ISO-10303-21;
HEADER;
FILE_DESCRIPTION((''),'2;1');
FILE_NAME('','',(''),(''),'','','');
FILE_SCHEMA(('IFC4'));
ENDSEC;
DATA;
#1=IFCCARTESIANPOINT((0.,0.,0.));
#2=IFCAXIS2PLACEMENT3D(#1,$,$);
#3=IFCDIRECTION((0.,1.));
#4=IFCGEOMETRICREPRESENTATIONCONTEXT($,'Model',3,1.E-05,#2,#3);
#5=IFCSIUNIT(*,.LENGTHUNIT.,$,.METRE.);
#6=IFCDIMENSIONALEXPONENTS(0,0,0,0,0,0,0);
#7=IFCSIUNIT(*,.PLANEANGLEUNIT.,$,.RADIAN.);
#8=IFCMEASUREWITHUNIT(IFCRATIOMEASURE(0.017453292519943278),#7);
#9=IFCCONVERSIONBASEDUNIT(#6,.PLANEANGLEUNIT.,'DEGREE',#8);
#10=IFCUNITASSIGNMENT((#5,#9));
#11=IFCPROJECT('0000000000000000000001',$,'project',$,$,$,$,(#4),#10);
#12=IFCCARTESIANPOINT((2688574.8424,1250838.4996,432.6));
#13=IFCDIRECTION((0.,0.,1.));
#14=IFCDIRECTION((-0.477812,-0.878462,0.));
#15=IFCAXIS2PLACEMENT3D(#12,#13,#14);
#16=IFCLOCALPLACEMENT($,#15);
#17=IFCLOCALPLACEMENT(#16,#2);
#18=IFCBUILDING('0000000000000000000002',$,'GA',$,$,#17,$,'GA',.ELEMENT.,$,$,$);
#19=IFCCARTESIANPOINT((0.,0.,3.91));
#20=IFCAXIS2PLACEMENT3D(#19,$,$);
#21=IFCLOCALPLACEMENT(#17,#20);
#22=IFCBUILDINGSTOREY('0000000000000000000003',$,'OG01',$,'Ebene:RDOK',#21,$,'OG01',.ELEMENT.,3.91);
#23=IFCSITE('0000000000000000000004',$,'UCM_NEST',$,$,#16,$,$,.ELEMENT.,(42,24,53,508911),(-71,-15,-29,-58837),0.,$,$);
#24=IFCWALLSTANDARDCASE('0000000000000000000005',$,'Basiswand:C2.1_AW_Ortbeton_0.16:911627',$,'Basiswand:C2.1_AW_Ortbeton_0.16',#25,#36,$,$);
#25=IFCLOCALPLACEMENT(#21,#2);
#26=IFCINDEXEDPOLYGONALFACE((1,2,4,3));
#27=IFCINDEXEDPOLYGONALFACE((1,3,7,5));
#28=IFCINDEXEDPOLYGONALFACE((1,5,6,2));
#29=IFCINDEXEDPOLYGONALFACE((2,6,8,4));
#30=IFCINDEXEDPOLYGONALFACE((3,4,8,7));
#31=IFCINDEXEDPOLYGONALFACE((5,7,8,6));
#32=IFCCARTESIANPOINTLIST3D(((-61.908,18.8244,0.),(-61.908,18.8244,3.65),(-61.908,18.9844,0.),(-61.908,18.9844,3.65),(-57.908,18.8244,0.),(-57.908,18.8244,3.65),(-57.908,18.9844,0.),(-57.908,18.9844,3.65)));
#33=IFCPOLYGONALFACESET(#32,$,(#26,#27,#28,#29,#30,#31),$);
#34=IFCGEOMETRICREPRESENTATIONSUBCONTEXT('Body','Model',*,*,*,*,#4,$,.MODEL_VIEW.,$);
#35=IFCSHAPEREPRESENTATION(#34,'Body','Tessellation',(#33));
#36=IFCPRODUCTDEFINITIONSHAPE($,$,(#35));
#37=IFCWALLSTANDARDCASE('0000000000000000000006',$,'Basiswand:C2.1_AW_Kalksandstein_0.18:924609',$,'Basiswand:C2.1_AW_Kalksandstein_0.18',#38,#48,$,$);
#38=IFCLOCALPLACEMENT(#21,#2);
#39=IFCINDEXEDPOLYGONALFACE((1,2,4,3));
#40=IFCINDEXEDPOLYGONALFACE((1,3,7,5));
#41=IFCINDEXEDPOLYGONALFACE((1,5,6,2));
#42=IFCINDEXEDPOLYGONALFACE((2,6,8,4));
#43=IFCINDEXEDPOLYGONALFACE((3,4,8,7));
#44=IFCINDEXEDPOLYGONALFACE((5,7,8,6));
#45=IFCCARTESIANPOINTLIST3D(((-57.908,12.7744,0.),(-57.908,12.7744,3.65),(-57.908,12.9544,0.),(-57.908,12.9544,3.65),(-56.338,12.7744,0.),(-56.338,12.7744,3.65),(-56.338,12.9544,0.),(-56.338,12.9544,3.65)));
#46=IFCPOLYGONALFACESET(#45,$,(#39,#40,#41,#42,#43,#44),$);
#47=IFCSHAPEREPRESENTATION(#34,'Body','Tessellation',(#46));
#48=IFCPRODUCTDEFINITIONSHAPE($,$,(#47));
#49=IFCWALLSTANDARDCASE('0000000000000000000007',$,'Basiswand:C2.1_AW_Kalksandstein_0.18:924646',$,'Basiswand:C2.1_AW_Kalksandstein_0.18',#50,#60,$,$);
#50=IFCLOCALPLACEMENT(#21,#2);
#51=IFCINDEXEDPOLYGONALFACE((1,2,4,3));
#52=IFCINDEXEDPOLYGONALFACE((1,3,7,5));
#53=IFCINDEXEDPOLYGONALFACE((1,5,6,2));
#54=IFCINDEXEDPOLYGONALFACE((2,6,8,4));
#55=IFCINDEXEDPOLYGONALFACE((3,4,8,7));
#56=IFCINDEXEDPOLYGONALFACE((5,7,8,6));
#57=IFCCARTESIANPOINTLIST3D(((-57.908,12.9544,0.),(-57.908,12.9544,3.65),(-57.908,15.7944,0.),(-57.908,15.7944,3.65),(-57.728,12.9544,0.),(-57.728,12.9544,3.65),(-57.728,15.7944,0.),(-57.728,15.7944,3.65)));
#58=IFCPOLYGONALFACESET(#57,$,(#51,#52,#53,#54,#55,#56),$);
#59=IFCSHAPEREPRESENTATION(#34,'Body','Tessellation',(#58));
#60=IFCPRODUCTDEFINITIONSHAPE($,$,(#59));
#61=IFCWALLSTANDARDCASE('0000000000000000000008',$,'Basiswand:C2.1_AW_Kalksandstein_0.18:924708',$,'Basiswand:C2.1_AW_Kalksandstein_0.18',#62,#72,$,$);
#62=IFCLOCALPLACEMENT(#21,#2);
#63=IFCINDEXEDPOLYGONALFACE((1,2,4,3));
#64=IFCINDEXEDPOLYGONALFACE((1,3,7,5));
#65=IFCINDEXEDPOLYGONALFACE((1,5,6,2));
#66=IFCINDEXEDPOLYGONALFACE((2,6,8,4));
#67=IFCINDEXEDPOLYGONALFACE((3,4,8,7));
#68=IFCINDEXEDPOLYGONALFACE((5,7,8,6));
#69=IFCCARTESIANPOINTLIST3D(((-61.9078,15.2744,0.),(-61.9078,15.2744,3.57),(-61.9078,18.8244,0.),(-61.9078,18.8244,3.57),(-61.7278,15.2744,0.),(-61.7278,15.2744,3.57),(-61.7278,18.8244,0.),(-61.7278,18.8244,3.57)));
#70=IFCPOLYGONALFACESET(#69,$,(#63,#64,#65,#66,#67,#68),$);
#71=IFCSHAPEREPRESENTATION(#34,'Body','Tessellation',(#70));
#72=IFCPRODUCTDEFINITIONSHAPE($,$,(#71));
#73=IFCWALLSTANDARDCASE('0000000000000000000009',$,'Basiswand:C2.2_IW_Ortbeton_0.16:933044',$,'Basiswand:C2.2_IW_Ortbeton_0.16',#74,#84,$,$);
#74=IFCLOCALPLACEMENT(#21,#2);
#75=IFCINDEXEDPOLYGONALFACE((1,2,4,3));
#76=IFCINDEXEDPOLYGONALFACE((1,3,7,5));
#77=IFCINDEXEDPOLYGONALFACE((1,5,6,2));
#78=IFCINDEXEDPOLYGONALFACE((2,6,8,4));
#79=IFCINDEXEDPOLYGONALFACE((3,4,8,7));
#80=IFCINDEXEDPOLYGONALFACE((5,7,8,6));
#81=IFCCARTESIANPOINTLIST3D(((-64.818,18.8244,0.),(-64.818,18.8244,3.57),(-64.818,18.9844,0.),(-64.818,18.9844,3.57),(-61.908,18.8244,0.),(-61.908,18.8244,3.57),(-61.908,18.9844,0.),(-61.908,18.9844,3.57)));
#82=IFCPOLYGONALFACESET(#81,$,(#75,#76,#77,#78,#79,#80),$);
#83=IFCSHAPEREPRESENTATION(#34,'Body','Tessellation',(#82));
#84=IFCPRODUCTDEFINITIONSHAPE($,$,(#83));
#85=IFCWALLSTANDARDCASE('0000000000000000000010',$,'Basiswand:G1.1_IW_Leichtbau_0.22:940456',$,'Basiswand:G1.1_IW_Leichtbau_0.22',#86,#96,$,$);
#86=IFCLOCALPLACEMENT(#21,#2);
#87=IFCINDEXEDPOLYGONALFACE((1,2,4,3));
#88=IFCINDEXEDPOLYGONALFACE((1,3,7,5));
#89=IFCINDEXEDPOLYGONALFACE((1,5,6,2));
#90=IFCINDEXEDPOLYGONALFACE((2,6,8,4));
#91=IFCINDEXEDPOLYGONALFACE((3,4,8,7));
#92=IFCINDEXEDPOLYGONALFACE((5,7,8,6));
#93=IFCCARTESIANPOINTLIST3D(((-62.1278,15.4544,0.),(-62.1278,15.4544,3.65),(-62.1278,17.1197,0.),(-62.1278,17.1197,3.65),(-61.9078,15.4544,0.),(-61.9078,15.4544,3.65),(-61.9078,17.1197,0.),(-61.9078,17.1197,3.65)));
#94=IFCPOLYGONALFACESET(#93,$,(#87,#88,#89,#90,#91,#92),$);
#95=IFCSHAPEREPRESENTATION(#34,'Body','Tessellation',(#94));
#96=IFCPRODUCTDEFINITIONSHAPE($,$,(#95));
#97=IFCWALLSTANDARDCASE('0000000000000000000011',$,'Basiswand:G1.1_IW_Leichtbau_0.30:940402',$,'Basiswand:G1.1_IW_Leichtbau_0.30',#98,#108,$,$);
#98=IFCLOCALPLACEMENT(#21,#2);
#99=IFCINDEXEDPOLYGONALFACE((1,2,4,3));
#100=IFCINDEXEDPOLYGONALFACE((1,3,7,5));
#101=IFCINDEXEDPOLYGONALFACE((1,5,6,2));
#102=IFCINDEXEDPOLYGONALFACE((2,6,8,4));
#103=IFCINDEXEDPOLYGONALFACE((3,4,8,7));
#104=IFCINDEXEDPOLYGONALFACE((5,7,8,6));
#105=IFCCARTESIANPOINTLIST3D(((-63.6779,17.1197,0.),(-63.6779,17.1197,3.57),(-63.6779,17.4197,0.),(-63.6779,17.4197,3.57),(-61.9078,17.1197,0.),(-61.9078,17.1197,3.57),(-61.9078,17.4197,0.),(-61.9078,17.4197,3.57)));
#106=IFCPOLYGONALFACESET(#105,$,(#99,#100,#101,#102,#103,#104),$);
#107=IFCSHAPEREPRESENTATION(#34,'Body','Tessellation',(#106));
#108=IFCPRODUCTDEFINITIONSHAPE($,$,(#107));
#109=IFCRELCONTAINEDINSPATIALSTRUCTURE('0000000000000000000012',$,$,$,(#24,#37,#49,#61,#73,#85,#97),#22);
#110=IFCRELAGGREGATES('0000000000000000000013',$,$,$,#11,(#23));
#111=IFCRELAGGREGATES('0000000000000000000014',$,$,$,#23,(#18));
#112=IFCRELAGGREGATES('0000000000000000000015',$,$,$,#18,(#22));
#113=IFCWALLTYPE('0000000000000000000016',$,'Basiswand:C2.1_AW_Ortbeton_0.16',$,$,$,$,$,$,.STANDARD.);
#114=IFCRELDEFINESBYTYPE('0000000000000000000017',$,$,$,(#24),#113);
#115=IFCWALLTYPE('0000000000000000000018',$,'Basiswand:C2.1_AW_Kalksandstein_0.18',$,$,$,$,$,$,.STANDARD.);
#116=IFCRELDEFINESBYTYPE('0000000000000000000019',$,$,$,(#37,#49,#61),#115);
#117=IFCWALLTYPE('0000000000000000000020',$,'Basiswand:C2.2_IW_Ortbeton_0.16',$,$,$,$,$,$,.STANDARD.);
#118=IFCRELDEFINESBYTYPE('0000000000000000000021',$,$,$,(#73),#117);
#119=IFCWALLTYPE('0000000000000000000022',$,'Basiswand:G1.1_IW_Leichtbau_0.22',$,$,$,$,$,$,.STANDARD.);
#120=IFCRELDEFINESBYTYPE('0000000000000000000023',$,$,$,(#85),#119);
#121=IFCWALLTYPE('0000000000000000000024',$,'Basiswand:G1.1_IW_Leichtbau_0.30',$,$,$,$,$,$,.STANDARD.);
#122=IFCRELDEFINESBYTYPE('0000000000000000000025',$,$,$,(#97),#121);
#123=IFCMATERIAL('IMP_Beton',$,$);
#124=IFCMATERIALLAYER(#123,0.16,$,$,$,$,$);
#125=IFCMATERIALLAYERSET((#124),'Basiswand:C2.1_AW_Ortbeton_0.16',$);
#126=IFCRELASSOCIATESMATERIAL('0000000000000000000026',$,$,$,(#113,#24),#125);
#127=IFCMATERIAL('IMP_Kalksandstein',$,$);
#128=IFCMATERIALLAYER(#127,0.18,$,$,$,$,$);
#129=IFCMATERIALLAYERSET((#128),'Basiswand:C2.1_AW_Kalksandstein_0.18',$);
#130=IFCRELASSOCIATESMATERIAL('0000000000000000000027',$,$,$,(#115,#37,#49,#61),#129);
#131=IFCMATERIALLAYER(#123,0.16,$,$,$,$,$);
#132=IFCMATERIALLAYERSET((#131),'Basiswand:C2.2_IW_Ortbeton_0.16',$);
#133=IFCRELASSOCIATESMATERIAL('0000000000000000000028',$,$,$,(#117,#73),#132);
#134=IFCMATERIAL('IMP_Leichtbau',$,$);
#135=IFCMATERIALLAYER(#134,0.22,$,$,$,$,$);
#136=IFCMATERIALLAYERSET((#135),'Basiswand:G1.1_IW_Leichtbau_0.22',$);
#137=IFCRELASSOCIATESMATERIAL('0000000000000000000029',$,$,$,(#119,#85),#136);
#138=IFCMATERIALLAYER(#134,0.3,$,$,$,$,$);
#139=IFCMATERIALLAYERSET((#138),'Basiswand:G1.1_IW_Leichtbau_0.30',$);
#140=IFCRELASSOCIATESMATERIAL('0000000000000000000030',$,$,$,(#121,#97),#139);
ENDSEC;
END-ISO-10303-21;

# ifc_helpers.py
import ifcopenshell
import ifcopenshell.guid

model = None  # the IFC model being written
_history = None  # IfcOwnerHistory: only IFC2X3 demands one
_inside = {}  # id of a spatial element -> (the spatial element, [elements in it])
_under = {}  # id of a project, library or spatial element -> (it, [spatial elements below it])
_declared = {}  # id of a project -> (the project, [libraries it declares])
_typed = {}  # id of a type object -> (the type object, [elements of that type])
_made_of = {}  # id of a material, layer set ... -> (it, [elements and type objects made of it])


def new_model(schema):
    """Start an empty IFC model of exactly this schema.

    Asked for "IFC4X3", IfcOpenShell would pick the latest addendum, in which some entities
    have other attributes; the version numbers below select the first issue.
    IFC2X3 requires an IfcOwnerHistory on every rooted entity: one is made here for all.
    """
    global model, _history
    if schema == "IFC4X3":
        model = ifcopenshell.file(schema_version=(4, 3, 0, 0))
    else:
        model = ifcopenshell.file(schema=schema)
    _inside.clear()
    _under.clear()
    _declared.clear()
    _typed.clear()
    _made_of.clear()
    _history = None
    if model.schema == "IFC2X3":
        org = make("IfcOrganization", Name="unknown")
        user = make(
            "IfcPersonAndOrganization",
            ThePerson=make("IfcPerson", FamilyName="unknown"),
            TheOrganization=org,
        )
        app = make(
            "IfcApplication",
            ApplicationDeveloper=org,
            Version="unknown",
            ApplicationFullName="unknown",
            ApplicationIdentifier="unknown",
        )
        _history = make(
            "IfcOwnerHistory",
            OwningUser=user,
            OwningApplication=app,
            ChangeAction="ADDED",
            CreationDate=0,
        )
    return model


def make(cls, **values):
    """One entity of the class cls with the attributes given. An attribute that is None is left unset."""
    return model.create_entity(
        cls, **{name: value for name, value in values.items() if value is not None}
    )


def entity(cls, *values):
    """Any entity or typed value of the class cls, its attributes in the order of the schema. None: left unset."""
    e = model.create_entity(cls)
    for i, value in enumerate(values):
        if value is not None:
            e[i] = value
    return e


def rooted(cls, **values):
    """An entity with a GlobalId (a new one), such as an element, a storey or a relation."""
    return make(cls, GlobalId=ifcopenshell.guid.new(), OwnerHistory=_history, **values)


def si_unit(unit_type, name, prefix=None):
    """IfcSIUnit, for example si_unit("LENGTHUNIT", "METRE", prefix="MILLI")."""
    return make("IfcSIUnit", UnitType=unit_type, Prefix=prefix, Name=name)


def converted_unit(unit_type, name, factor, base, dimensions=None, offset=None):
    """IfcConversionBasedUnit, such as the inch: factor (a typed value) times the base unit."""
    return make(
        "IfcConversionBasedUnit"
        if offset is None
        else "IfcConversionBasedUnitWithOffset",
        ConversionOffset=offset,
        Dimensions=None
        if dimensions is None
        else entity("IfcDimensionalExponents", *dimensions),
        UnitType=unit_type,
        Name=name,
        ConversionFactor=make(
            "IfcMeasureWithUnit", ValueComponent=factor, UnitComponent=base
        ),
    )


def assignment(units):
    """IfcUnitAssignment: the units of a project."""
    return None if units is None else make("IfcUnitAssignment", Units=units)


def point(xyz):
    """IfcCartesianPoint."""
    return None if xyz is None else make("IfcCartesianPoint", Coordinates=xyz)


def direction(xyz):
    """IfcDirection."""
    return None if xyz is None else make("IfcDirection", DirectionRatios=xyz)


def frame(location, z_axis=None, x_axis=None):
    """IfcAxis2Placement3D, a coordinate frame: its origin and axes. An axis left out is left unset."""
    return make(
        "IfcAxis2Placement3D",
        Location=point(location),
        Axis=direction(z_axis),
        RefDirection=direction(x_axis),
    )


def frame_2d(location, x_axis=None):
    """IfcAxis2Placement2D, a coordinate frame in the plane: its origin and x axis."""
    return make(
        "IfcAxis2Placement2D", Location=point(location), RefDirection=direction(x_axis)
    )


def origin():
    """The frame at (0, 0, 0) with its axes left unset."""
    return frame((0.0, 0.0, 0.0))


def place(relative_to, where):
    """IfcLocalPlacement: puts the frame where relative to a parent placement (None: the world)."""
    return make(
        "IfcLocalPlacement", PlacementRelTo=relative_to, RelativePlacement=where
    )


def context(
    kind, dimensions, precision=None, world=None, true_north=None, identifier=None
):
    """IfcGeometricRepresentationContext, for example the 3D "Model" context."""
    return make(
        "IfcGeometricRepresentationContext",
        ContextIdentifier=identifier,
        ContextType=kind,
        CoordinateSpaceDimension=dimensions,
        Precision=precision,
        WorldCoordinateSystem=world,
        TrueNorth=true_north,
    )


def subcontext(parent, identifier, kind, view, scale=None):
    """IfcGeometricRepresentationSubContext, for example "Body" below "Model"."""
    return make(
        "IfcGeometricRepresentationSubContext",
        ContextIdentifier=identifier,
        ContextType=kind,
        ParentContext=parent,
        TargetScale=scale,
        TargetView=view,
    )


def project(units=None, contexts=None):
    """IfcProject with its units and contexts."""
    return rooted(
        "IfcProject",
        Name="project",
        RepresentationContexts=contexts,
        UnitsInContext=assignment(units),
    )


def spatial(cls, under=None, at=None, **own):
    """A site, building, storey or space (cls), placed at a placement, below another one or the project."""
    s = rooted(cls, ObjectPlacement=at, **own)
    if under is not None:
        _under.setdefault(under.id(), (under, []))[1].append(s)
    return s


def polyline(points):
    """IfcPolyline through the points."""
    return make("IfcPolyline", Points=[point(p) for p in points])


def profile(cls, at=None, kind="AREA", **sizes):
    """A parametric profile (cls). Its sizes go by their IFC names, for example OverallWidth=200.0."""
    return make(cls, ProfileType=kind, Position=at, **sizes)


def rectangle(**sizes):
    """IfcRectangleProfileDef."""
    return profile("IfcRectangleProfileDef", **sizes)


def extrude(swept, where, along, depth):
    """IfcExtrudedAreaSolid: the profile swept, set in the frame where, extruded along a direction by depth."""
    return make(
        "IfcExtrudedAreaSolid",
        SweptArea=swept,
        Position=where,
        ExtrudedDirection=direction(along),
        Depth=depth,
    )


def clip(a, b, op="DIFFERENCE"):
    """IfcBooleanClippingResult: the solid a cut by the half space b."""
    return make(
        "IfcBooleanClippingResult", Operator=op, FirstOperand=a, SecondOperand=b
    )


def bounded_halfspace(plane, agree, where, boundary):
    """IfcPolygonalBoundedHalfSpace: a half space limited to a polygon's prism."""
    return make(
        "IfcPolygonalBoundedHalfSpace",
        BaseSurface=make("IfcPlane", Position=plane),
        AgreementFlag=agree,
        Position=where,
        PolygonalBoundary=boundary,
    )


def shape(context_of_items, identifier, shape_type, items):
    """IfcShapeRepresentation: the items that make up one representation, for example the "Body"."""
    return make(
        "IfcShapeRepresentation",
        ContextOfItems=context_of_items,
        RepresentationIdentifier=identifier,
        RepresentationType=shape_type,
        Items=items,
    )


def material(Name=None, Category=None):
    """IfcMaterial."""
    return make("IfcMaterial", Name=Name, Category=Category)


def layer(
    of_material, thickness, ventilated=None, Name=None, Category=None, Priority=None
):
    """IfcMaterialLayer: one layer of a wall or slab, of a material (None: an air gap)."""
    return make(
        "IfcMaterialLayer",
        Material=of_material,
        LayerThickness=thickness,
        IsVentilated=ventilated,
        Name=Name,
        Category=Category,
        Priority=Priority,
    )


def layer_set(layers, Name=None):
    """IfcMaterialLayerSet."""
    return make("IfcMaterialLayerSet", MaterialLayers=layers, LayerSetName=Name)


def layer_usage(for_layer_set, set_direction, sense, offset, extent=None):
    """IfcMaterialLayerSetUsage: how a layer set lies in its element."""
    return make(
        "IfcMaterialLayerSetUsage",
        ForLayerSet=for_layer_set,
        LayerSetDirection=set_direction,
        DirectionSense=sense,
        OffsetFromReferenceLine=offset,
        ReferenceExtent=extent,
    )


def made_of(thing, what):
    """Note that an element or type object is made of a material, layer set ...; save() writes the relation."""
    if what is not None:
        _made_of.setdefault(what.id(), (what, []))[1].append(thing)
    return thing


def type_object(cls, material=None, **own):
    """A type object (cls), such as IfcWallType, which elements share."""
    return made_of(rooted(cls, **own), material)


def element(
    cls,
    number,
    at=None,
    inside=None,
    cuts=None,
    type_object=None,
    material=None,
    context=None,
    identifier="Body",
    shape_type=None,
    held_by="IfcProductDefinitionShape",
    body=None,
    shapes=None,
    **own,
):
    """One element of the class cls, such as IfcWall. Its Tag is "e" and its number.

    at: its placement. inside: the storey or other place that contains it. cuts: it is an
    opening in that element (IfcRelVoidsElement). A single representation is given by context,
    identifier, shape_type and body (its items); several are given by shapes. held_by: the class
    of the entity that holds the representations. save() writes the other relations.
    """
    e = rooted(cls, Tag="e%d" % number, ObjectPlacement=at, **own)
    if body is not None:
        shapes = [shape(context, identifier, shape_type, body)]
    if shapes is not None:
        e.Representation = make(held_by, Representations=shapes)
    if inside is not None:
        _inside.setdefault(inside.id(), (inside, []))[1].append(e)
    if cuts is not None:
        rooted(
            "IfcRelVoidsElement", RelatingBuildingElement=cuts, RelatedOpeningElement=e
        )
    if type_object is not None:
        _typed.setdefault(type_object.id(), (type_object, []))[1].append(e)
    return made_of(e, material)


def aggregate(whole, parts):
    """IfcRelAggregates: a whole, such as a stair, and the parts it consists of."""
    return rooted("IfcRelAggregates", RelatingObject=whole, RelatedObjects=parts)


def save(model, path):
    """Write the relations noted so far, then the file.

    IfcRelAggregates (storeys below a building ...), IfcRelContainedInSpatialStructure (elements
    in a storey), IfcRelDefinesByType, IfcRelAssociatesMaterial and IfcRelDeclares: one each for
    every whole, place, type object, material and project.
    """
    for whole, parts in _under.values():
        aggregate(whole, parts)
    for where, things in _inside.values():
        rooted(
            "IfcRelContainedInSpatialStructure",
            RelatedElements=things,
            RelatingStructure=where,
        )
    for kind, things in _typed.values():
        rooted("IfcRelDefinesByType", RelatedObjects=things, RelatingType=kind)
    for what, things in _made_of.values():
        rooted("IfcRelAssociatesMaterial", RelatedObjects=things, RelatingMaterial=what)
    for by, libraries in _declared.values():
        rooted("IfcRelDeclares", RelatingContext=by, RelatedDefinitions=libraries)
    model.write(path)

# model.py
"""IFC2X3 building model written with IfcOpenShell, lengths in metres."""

from ifc_helpers import new_model, entity, si_unit, converted_unit, direction, frame, frame_2d, origin, place, context, subcontext, project, spatial, polyline, rectangle, extrude, clip, bounded_halfspace, material, layer, layer_set, layer_usage, type_object, element, save


model = new_model("IFC2X3")

# Units and contexts
model_context = context("Model", 3, precision=1e-05, world=origin(), true_north=direction((0.0, 1.0)))
body_context = subcontext(model_context, "Body", "Model", "MODEL_VIEW")
ifc_project = project(units=[si_unit("LENGTHUNIT", "METRE"), converted_unit("PLANEANGLEUNIT", "DEGREE", entity("IfcRatioMeasure", 0.017453292519943278), si_unit("PLANEANGLEUNIT", "RADIAN"), dimensions=[0, 0, 0, 0, 0, 0, 0])], contexts=[model_context])

# Site, building, storey
site_placement = place(None, frame((2688574.8424, 1250838.4996, 432.6), z_axis=(0.0, 0.0, 1.0), x_axis=(-0.477812, -0.878462, 0.0)))
site = spatial("IfcSite", under=ifc_project, at=site_placement, Name="UCM_NEST", CompositionType="ELEMENT", RefLatitude=(42, 24, 53, 508911), RefLongitude=(-71, -15, -29, -58837), RefElevation=0.0)
building_placement = place(site_placement, origin())
building = spatial("IfcBuilding", under=site, at=building_placement, Name="GA", LongName="GA", CompositionType="ELEMENT")
storey_placement = place(building_placement, frame((0.0, 0.0, 3.91)))
storey = spatial("IfcBuildingStorey", under=building, at=storey_placement, Name="OG01", ObjectType="Ebene:RDOK", LongName="OG01", CompositionType="ELEMENT", Elevation=3.91)

# Shared definitions
ifc_material_1 = material(Name="IMP_Beton")
ifc_layer_1 = layer(ifc_material_1, 0.16)
ifc_layer_set_1 = layer_set([ifc_layer_1], Name="Basiswand:C2.1_AW_Ortbeton_0.16")
ifc_layer_usage_1 = layer_usage(ifc_layer_set_1, "AXIS2", "NEGATIVE", 0.08)
wall_type_1 = type_object("IfcWallType", Name="Basiswand:C2.1_AW_Ortbeton_0.16", PredefinedType="STANDARD", material=ifc_layer_set_1)

# Walls
wall_1_placement = place(storey_placement, frame((-57.908, 18.9044, 0.0), z_axis=(0.0, 0.0, 1.0), x_axis=(-1.0, 0.0, 0.0)))
element("IfcWallStandardCase", 1, at=wall_1_placement, inside=storey, type_object=wall_type_1, material=ifc_layer_usage_1, Name="Basiswand:C2.1_AW_Ortbeton_0.16:911627", ObjectType="Basiswand:C2.1_AW_Ortbeton_0.16", context=body_context, shape_type="SweptSolid", body=[
    extrude(rectangle(XDim=4.0, YDim=0.16, at=frame_2d((2.0, 0.0), x_axis=(-1.0, 0.0))), origin(), (0.0, 0.0, 1.0), 3.65),
])
ifc_material_2 = material(Name="IMP_Kalksandstein")
ifc_layer_2 = layer(ifc_material_2, 0.18)
ifc_layer_set_2 = layer_set([ifc_layer_2], Name="Basiswand:C2.1_AW_Kalksandstein_0.18")
ifc_layer_usage_2 = layer_usage(ifc_layer_set_2, "AXIS2", "NEGATIVE", 0.09)
wall_type_2 = type_object("IfcWallType", Name="Basiswand:C2.1_AW_Kalksandstein_0.18", PredefinedType="STANDARD", material=ifc_layer_set_2)
wall_2_placement = place(storey_placement, frame((-56.338, 12.8644, 0.0), z_axis=(0.0, 0.0, 1.0), x_axis=(-1.0, 0.0, 0.0)))
element("IfcWallStandardCase", 2, at=wall_2_placement, inside=storey, type_object=wall_type_2, material=ifc_layer_usage_2, Name="Basiswand:C2.1_AW_Kalksandstein_0.18:924609", ObjectType="Basiswand:C2.1_AW_Kalksandstein_0.18", context=body_context, shape_type="SweptSolid", body=[
    extrude(rectangle(XDim=1.57, YDim=0.18, at=frame_2d((0.785, 0.0), x_axis=(-1.0, 0.0))), origin(), (0.0, 0.0, 1.0), 3.65),
])
wall_3_placement = place(storey_placement, frame((-57.818, 12.9544, 0.0), z_axis=(0.0, 0.0, 1.0), x_axis=(0.0, 1.0, 0.0)))
element("IfcWallStandardCase", 3, at=wall_3_placement, inside=storey, type_object=wall_type_2, material=ifc_layer_usage_2, Name="Basiswand:C2.1_AW_Kalksandstein_0.18:924646", ObjectType="Basiswand:C2.1_AW_Kalksandstein_0.18", context=body_context, shape_type="SweptSolid", body=[
    extrude(rectangle(XDim=2.84, YDim=0.18, at=frame_2d((1.42, 0.0), x_axis=(-1.0, 0.0))), origin(), (0.0, 0.0, 1.0), 3.65),
])
wall_4_placement = place(storey_placement, frame((-61.8178, 18.8244, 0.0), z_axis=(0.0, 0.0, 1.0), x_axis=(0.0, -1.0, 0.0)))
element("IfcWallStandardCase", 4, at=wall_4_placement, inside=storey, type_object=wall_type_2, material=ifc_layer_usage_2, Name="Basiswand:C2.1_AW_Kalksandstein_0.18:924708", ObjectType="Basiswand:C2.1_AW_Kalksandstein_0.18", context=body_context, shape_type="Clipping", body=[
    clip(extrude(rectangle(XDim=3.55, YDim=0.18, at=frame_2d((1.775, 0.0), x_axis=(-1.0, 0.0))), origin(), (0.0, 0.0, 1.0), 3.57), bounded_halfspace(frame((0.0, -0.09, 3.57), z_axis=(0.0, 0.0, -1.0), x_axis=(1.0, 0.0, 0.0)), True, frame((0.0, -0.09, 3.57), z_axis=(0.0, 0.0, -1.0), x_axis=(1.0, 0.0, 0.0)), polyline([(0.0, 0.0), (0.0, -0.18), (3.55, -0.18), (3.55, 0.0), (3.37, 0.0), (1.7048, 0.0), (1.4048, 0.0), (0.0, 0.0)]))),
])

# Wall
ifc_layer_3 = layer(ifc_material_1, 0.16)
ifc_layer_set_3 = layer_set([ifc_layer_3], Name="Basiswand:C2.2_IW_Ortbeton_0.16")
ifc_layer_usage_3 = layer_usage(ifc_layer_set_3, "AXIS2", "NEGATIVE", 0.08)
wall_type_3 = type_object("IfcWallType", Name="Basiswand:C2.2_IW_Ortbeton_0.16", PredefinedType="STANDARD", material=ifc_layer_set_3)
wall_5_placement = place(storey_placement, frame((-61.908, 18.9044, 0.0), z_axis=(0.0, 0.0, 1.0), x_axis=(-1.0, 0.0, 0.0)))
element("IfcWallStandardCase", 5, at=wall_5_placement, inside=storey, type_object=wall_type_3, material=ifc_layer_usage_3, Name="Basiswand:C2.2_IW_Ortbeton_0.16:933044", ObjectType="Basiswand:C2.2_IW_Ortbeton_0.16", context=body_context, shape_type="Clipping", body=[
    clip(extrude(rectangle(XDim=2.91, YDim=0.16, at=frame_2d((1.455, 0.0), x_axis=(-1.0, 0.0))), origin(), (0.0, 0.0, 1.0), 3.57), bounded_halfspace(frame((0.0, -0.08, 3.57), z_axis=(0.0, 0.0, -1.0), x_axis=(0.0, 1.0, 0.0)), True, frame((0.0, -0.08, 3.57), z_axis=(0.0, 0.0, -1.0), x_axis=(0.0, 1.0, 0.0)), polyline([(0.0, 0.0), (0.16, 0.0), (0.16, 2.91), (0.0, 2.91), (0.0, 0.0)]))),
])

# Wall
ifc_material_3 = material(Name="IMP_Leichtbau")
ifc_layer_4 = layer(ifc_material_3, 0.22)
ifc_layer_set_4 = layer_set([ifc_layer_4], Name="Basiswand:G1.1_IW_Leichtbau_0.22")
ifc_layer_usage_4 = layer_usage(ifc_layer_set_4, "AXIS2", "NEGATIVE", 0.11)
wall_type_4 = type_object("IfcWallType", Name="Basiswand:G1.1_IW_Leichtbau_0.22", PredefinedType="STANDARD", material=ifc_layer_set_4)
wall_6_placement = place(storey_placement, frame((-62.0178, 15.4544, 0.0), z_axis=(0.0, 0.0, 1.0), x_axis=(0.0, 1.0, 0.0)))
element("IfcWallStandardCase", 6, at=wall_6_placement, inside=storey, type_object=wall_type_4, material=ifc_layer_usage_4, Name="Basiswand:G1.1_IW_Leichtbau_0.22:940456", ObjectType="Basiswand:G1.1_IW_Leichtbau_0.22", context=body_context, shape_type="SweptSolid", body=[
    extrude(rectangle(XDim=1.6652, YDim=0.22, at=frame_2d((0.8326, 0.0), x_axis=(-1.0, 0.0))), origin(), (0.0, 0.0, 1.0), 3.65),
])

# Wall
ifc_layer_5 = layer(ifc_material_3, 0.3)
ifc_layer_set_5 = layer_set([ifc_layer_5], Name="Basiswand:G1.1_IW_Leichtbau_0.30")
ifc_layer_usage_5 = layer_usage(ifc_layer_set_5, "AXIS2", "NEGATIVE", 0.15)
wall_type_5 = type_object("IfcWallType", Name="Basiswand:G1.1_IW_Leichtbau_0.30", PredefinedType="STANDARD", material=ifc_layer_set_5)
wall_7_placement = place(storey_placement, frame((-63.6779, 17.2697, 0.0)))
element("IfcWallStandardCase", 7, at=wall_7_placement, inside=storey, type_object=wall_type_5, material=ifc_layer_usage_5, Name="Basiswand:G1.1_IW_Leichtbau_0.30:940402", ObjectType="Basiswand:G1.1_IW_Leichtbau_0.30", context=body_context, shape_type="Clipping", body=[
    clip(extrude(rectangle(XDim=1.7702, YDim=0.3, at=frame_2d((0.8851, 0.0), x_axis=(-1.0, 0.0))), origin(), (0.0, 0.0, 1.0), 3.57), bounded_halfspace(frame((0.0, -0.15, 3.57), z_axis=(0.0, 0.0, -1.0), x_axis=(0.0, -1.0, 0.0)), True, frame((0.0, -0.15, 3.57), z_axis=(0.0, 0.0, -1.0), x_axis=(0.0, -1.0, 0.0)), polyline([(0.0, 0.0), (-0.3, 0.0), (-0.3, -1.7702), (0.0, -1.7702), (0.0, 0.0)]))),
])

save(model, "model.ifc")
